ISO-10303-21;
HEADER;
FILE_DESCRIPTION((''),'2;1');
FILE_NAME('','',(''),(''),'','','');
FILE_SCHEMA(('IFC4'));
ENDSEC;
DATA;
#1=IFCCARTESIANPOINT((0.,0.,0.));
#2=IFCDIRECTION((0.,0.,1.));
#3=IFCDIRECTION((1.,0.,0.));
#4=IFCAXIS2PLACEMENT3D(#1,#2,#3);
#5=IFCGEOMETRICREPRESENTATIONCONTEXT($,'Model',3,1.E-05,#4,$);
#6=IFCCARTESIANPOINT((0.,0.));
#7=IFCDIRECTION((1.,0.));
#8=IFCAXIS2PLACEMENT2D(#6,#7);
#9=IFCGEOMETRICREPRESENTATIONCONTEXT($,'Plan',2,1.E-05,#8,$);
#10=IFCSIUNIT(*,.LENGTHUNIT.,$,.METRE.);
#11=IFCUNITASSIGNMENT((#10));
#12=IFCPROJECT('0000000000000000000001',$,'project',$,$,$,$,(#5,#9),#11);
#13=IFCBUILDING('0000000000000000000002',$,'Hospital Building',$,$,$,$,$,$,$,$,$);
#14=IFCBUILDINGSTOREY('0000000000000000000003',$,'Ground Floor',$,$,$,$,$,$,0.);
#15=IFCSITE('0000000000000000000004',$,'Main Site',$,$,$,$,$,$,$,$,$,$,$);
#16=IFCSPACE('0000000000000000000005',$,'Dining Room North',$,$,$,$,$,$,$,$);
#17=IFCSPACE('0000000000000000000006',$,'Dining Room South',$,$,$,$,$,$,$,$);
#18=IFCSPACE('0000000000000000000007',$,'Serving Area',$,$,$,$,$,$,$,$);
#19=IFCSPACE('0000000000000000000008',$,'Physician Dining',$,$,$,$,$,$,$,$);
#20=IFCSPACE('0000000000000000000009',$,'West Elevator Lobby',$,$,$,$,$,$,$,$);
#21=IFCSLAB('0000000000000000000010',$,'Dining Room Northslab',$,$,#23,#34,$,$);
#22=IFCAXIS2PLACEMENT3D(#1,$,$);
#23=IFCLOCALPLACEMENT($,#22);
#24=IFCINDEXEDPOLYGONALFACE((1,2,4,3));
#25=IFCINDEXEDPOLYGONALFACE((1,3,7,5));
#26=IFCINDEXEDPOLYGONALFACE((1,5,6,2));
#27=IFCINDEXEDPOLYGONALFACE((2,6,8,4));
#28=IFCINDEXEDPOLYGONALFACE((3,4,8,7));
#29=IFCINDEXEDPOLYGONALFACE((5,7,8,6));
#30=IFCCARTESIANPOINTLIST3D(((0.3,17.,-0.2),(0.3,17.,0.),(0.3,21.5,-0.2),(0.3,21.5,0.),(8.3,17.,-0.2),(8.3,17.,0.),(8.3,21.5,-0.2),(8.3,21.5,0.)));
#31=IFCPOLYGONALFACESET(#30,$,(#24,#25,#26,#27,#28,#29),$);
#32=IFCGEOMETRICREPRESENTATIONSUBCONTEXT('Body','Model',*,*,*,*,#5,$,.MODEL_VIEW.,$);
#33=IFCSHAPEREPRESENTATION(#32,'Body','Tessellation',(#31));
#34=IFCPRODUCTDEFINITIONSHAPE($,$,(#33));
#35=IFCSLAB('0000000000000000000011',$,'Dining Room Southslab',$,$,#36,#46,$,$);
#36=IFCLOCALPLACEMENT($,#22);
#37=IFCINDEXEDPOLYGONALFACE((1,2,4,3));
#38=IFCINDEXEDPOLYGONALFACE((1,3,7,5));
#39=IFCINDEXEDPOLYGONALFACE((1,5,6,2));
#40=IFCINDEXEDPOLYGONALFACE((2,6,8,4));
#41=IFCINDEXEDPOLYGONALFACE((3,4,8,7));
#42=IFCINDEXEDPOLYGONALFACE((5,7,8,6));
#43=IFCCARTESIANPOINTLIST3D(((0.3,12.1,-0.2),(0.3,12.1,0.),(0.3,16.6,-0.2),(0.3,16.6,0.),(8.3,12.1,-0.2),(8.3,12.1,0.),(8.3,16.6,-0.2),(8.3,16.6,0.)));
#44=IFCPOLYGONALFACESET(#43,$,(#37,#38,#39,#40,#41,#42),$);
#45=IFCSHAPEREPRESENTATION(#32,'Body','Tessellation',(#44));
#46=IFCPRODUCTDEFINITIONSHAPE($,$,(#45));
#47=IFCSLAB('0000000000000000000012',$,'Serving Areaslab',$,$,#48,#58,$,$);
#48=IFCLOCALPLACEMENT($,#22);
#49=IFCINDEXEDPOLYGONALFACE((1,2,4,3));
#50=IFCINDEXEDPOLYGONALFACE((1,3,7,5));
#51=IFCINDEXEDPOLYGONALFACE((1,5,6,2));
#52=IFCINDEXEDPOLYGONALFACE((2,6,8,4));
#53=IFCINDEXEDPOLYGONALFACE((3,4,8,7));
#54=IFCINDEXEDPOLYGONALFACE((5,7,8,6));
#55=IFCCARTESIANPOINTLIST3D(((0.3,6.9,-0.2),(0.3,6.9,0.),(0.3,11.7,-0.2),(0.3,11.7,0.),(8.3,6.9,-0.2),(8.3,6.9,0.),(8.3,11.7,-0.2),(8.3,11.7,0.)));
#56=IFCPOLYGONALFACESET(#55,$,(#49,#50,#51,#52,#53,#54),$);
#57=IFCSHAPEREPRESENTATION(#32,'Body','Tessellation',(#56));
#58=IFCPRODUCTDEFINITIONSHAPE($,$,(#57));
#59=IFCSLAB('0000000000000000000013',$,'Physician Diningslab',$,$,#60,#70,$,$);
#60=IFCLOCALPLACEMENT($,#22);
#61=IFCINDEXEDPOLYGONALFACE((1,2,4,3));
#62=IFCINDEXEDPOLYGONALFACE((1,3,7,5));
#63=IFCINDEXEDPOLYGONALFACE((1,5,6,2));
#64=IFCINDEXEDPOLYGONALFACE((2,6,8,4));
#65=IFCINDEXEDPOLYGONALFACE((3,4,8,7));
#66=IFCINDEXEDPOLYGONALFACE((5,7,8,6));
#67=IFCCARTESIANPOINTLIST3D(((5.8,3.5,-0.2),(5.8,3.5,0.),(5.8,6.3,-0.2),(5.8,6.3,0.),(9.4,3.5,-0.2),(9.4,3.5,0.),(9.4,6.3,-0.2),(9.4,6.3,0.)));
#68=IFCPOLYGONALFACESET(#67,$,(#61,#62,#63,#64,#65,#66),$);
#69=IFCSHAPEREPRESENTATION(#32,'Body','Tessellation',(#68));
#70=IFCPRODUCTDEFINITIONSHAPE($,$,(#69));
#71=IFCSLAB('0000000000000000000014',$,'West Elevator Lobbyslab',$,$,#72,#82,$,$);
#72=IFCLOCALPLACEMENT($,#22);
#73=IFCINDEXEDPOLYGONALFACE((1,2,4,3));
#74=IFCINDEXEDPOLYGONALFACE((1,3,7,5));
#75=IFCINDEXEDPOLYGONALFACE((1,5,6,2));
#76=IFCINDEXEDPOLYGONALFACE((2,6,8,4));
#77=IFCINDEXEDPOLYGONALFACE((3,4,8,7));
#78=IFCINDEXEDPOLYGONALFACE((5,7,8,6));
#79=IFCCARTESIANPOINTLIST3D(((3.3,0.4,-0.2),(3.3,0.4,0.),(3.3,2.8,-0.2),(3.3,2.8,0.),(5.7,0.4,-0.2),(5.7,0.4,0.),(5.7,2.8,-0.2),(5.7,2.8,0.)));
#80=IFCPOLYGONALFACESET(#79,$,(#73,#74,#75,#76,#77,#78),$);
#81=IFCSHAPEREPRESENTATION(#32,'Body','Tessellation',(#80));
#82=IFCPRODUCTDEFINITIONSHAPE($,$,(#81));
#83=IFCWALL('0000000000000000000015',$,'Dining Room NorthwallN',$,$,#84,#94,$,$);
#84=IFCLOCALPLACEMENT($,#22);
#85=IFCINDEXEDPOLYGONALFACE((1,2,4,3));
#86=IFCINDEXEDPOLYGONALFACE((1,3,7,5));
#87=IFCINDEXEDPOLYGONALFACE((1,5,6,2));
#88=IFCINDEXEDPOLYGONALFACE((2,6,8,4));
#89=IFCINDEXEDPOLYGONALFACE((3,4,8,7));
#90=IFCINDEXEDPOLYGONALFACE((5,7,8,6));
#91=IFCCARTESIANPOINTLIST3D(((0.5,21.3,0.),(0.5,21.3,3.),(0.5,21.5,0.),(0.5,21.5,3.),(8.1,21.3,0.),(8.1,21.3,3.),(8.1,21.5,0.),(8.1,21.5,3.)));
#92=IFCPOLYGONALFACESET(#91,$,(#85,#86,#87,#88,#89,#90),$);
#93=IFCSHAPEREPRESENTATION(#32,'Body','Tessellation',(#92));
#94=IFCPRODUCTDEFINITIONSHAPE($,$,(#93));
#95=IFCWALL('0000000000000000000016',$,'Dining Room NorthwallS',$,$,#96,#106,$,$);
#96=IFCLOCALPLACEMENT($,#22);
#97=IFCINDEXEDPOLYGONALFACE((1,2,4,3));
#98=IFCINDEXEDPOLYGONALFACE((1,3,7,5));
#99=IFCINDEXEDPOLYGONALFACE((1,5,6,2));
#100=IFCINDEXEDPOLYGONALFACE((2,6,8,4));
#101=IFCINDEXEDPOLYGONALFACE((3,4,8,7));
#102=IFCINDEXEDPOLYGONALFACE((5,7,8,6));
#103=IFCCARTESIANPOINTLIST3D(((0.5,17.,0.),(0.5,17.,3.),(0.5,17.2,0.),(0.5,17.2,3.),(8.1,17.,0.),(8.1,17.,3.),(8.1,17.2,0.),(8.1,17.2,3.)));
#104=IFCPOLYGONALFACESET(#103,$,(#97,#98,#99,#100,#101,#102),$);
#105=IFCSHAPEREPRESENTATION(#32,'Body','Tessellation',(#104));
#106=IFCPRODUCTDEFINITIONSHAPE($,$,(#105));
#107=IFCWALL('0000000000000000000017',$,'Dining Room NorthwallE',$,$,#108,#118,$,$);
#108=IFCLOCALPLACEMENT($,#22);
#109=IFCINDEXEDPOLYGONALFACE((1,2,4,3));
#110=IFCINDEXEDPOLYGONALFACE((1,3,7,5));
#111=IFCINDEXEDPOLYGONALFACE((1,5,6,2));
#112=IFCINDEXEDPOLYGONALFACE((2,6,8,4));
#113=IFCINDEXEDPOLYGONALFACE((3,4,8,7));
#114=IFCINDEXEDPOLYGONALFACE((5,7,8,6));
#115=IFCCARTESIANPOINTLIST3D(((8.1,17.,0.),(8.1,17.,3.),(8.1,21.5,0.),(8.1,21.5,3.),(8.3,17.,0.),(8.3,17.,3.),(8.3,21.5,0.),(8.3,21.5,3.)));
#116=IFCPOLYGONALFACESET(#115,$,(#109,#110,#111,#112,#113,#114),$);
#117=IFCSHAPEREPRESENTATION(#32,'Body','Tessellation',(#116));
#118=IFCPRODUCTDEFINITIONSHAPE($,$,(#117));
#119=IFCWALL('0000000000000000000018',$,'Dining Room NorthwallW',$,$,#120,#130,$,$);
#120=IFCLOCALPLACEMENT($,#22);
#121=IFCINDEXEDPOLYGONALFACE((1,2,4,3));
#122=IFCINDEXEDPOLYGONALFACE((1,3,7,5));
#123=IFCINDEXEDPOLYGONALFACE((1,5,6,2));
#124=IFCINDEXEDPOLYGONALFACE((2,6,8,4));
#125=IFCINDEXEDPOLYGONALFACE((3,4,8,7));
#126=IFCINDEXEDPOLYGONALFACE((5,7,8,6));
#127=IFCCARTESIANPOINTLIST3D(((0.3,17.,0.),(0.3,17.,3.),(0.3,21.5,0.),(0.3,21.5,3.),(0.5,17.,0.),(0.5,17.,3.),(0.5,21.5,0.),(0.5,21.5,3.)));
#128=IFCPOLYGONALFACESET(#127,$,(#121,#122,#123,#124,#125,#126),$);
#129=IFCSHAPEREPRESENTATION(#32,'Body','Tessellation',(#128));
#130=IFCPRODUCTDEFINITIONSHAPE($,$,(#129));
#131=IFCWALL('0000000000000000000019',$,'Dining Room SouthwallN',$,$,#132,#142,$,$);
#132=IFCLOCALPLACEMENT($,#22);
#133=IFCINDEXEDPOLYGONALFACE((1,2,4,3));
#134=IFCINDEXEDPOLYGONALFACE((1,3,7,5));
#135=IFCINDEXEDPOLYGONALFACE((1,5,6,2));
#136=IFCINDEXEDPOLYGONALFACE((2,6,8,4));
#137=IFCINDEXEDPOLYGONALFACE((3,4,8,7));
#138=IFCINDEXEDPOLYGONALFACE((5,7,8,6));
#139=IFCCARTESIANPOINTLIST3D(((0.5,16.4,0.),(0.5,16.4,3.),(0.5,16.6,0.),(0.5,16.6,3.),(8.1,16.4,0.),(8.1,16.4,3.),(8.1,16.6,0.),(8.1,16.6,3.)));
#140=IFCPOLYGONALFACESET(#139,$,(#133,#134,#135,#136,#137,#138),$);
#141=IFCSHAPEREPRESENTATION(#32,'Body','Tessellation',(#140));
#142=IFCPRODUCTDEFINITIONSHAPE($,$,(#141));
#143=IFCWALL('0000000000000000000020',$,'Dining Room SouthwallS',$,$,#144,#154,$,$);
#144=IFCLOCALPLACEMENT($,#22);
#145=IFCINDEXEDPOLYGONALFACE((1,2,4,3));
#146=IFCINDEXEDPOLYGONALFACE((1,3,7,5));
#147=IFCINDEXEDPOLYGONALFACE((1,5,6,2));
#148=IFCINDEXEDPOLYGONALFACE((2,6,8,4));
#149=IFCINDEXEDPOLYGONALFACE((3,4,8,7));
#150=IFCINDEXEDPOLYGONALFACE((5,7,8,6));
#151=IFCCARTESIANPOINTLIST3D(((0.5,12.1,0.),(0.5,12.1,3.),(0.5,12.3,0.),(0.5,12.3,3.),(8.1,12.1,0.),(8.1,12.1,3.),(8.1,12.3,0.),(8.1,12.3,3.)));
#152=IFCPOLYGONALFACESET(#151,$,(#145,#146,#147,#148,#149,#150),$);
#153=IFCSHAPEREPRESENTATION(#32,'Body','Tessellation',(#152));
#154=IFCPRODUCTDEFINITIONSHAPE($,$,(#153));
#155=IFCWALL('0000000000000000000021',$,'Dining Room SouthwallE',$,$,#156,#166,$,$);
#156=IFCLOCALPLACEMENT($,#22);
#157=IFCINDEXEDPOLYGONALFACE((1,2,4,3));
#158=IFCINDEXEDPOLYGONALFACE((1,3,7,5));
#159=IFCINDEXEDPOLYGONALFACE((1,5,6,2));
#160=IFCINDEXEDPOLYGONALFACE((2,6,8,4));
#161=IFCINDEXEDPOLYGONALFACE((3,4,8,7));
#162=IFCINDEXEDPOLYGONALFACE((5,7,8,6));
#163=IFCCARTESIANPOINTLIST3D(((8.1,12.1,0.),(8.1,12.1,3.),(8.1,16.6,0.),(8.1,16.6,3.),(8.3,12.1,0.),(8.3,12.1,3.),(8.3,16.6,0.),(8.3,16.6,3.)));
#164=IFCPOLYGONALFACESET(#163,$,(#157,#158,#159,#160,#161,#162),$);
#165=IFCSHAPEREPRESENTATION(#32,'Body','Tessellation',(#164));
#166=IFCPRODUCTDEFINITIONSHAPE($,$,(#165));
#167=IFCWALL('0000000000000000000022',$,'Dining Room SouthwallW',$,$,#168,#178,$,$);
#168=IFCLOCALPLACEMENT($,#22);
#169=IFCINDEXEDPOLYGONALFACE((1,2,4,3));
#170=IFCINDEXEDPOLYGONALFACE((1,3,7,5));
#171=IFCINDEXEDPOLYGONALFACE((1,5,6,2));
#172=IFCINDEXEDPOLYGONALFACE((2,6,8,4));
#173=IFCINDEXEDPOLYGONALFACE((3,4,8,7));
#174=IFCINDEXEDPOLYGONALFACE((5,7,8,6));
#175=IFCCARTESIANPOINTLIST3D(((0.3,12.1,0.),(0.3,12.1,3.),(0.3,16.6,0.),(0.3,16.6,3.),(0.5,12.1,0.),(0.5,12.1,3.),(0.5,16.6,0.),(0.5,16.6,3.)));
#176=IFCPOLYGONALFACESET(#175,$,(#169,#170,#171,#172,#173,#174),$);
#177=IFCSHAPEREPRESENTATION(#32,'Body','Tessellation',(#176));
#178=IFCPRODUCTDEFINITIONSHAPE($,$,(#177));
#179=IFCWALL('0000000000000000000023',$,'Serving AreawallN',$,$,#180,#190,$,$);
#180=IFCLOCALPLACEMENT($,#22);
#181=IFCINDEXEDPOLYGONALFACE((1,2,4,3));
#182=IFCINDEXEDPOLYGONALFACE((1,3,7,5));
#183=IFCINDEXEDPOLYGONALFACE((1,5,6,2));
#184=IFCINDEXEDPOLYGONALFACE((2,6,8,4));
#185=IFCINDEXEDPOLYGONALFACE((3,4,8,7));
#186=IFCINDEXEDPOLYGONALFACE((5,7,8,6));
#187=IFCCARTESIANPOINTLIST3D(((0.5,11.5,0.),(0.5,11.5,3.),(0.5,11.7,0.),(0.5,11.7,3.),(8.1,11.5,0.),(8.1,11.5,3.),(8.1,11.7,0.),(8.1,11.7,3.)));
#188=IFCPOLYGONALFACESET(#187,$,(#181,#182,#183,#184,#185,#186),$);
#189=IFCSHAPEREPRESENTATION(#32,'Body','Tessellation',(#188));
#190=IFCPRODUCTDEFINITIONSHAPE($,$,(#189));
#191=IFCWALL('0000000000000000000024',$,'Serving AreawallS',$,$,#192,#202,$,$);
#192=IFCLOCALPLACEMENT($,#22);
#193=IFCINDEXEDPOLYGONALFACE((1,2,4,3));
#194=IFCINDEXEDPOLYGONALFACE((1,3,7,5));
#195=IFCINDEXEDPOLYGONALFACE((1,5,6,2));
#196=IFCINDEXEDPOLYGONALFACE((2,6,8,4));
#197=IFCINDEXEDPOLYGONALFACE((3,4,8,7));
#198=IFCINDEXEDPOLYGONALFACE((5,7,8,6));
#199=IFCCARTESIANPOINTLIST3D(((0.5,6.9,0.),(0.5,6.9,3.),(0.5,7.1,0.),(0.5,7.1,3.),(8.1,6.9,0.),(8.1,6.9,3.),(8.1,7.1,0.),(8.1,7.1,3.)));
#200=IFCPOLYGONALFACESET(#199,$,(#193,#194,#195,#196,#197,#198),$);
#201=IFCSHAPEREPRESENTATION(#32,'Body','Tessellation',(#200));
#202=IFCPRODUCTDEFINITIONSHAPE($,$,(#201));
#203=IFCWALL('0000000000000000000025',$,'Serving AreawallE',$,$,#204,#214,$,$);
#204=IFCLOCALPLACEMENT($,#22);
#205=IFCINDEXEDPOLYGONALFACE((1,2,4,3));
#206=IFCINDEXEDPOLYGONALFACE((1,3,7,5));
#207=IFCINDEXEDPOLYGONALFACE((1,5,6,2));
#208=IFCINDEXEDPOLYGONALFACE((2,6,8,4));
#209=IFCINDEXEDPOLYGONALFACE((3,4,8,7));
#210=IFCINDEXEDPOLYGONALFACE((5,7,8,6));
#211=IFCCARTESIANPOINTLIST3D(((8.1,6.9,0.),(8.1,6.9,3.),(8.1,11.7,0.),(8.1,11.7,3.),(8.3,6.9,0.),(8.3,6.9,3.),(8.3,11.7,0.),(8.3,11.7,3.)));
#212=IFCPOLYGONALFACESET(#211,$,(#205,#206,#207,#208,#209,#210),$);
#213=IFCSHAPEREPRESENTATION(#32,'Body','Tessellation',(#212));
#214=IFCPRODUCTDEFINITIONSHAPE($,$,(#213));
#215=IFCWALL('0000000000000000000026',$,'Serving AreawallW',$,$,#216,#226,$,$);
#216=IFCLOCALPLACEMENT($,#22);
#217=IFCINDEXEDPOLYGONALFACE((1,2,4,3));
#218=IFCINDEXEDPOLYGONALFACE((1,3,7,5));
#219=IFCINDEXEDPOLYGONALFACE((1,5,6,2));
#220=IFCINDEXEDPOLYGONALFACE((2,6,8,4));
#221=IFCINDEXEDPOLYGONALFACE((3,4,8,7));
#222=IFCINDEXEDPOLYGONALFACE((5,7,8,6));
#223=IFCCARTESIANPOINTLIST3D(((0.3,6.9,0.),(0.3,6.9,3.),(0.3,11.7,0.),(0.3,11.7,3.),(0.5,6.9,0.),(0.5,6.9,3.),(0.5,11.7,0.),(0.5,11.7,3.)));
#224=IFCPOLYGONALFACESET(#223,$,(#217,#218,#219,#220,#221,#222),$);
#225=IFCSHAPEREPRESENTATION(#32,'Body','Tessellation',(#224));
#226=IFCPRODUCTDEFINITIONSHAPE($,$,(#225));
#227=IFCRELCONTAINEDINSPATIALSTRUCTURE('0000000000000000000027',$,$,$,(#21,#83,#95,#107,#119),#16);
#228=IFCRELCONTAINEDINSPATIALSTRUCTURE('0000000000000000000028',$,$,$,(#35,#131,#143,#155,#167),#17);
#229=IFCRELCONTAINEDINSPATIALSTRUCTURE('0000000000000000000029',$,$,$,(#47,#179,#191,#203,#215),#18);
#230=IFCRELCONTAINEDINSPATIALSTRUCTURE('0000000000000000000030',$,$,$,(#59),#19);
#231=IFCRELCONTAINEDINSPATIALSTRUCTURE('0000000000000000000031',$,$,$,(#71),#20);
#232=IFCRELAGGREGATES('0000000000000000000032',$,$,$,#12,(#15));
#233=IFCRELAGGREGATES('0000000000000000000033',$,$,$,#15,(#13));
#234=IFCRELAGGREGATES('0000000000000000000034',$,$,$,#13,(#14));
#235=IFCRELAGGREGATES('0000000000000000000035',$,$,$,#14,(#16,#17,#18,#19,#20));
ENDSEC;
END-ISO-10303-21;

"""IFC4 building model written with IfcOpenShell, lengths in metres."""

from ifc_helpers import new_model, si_unit, frame, origin_with_axes, origin_2d_with_axis, place, context, subcontext, project, spatial, indexed_curve, rectangle, outline, extrude, element, save


model = new_model("IFC4")

# Units and contexts
model_context = context("Model", 3, precision=1e-05, world=origin_with_axes())
plan_context = context("Plan", 2, precision=1e-05, world=origin_2d_with_axis())
body_context = subcontext(model_context, "Body", "Model", "MODEL_VIEW")
ifc_project = project(units=[si_unit("LENGTHUNIT", "METRE")], contexts=[model_context, plan_context])

# Site, building, storey, space
site = spatial("IfcSite", under=ifc_project, Name="Main Site")
building = spatial("IfcBuilding", under=site, Name="Hospital Building")
storey = spatial("IfcBuildingStorey", under=building, Name="Ground Floor", Elevation=0.0)
space_1 = spatial("IfcSpace", under=storey, Name="Dining Room North")

# Slab
slab_1_placement = place(None, frame((4.3, 19.25, -0.2), z_axis=(0.0, 0.0, 1.0), x_axis=(1.0, 0.0, 0.0)))
element("IfcSlab", 1, at=slab_1_placement, inside=space_1, Name="Dining Room Northslab", context=body_context, shape_type="SweptSolid", body=[
    extrude(rectangle(XDim=8.0, YDim=4.5), origin_with_axes(), (0.0, 0.0, 1.0), 0.2),
])

# Shared definitions
space_2 = spatial("IfcSpace", under=storey, Name="Dining Room South")

# Slab
slab_2_placement = place(None, frame((4.3, 14.35, -0.2), z_axis=(0.0, 0.0, 1.0), x_axis=(1.0, 0.0, 0.0)))
element("IfcSlab", 2, at=slab_2_placement, inside=space_2, Name="Dining Room Southslab", context=body_context, shape_type="SweptSolid", body=[
    extrude(rectangle(XDim=8.0, YDim=4.5), origin_with_axes(), (0.0, 0.0, 1.0), 0.2),
])

# Shared definitions
space_3 = spatial("IfcSpace", under=storey, Name="Serving Area")

# Slab
slab_3_placement = place(None, frame((4.3, 9.3, -0.2), z_axis=(0.0, 0.0, 1.0), x_axis=(1.0, 0.0, 0.0)))
element("IfcSlab", 3, at=slab_3_placement, inside=space_3, Name="Serving Areaslab", context=body_context, shape_type="SweptSolid", body=[
    extrude(rectangle(XDim=8.0, YDim=4.8), origin_with_axes(), (0.0, 0.0, 1.0), 0.2),
])

# Shared definitions
space_4 = spatial("IfcSpace", under=storey, Name="Physician Dining")

# Slab
slab_4_placement = place(None, frame((7.6, 4.9, -0.2), z_axis=(0.0, 0.0, 1.0), x_axis=(1.0, 0.0, 0.0)))
element("IfcSlab", 4, at=slab_4_placement, inside=space_4, Name="Physician Diningslab", context=body_context, shape_type="SweptSolid", body=[
    extrude(rectangle(XDim=3.6, YDim=2.8), origin_with_axes(), (0.0, 0.0, 1.0), 0.2),
])

# Shared definitions
space_5 = spatial("IfcSpace", under=storey, Name="West Elevator Lobby")

# Slab
slab_5_placement = place(None, frame((4.5, 1.6, -0.2), z_axis=(0.0, 0.0, 1.0), x_axis=(1.0, 0.0, 0.0)))
element("IfcSlab", 5, at=slab_5_placement, inside=space_5, Name="West Elevator Lobbyslab", context=body_context, shape_type="SweptSolid", body=[
    extrude(rectangle(XDim=2.4, YDim=2.4), origin_with_axes(), (0.0, 0.0, 1.0), 0.2),
])

# Walls
for number, where, z_axis, x_axis, name in (
    (6, (0.5, 21.3, 0.0), (0.0, 0.0, 1.0), (1.0, 0.0, 0.0), "Dining Room NorthwallN"),
    (7, (0.5, 17.0, 0.0), (0.0, 0.0, 1.0), (1.0, 0.0, 0.0), "Dining Room NorthwallS"),
):
    element("IfcWall", number, at=place(None, frame(where, z_axis=z_axis, x_axis=x_axis)), inside=space_1, Name=name, context=body_context, shape_type="SweptSolid", body=[
        extrude(outline(indexed_curve([(0.0, 0.0), (0.0, 0.2), (7.6, 0.2), (7.6, 0.0), (0.0, 0.0)], self_intersect=False)), origin_with_axes(), (0.0, 0.0, 1.0), 3.0),
    ])
for number, where, z_axis, x_axis, name in (
    (8, (8.3, 17.0, 0.0), (0.0, 0.0, 1.0), (0.0, 1.0, 0.0), "Dining Room NorthwallE"),
    (9, (0.5, 17.0, 0.0), (0.0, 0.0, 1.0), (0.0, 1.0, 0.0), "Dining Room NorthwallW"),
):
    element("IfcWall", number, at=place(None, frame(where, z_axis=z_axis, x_axis=x_axis)), inside=space_1, Name=name, context=body_context, shape_type="SweptSolid", body=[
        extrude(outline(indexed_curve([(0.0, 0.0), (0.0, 0.2), (4.5, 0.2), (4.5, 0.0), (0.0, 0.0)], self_intersect=False)), origin_with_axes(), (0.0, 0.0, 1.0), 3.0),
    ])
for number, where, z_axis, x_axis, name in (
    (10, (0.5, 16.4, 0.0), (0.0, 0.0, 1.0), (1.0, 0.0, 0.0), "Dining Room SouthwallN"),
    (11, (0.5, 12.1, 0.0), (0.0, 0.0, 1.0), (1.0, 0.0, 0.0), "Dining Room SouthwallS"),
):
    element("IfcWall", number, at=place(None, frame(where, z_axis=z_axis, x_axis=x_axis)), inside=space_2, Name=name, context=body_context, shape_type="SweptSolid", body=[
        extrude(outline(indexed_curve([(0.0, 0.0), (0.0, 0.2), (7.6, 0.2), (7.6, 0.0), (0.0, 0.0)], self_intersect=False)), origin_with_axes(), (0.0, 0.0, 1.0), 3.0),
    ])
for number, where, z_axis, x_axis, name in (
    (12, (8.3, 12.1, 0.0), (0.0, 0.0, 1.0), (0.0, 1.0, 0.0), "Dining Room SouthwallE"),
    (13, (0.5, 12.1, 0.0), (0.0, 0.0, 1.0), (0.0, 1.0, 0.0), "Dining Room SouthwallW"),
):
    element("IfcWall", number, at=place(None, frame(where, z_axis=z_axis, x_axis=x_axis)), inside=space_2, Name=name, context=body_context, shape_type="SweptSolid", body=[
        extrude(outline(indexed_curve([(0.0, 0.0), (0.0, 0.2), (4.5, 0.2), (4.5, 0.0), (0.0, 0.0)], self_intersect=False)), origin_with_axes(), (0.0, 0.0, 1.0), 3.0),
    ])
for number, where, z_axis, x_axis, name in (
    (14, (0.5, 11.5, 0.0), (0.0, 0.0, 1.0), (1.0, 0.0, 0.0), "Serving AreawallN"),
    (15, (0.5, 6.9, 0.0), (0.0, 0.0, 1.0), (1.0, 0.0, 0.0), "Serving AreawallS"),
):
    element("IfcWall", number, at=place(None, frame(where, z_axis=z_axis, x_axis=x_axis)), inside=space_3, Name=name, context=body_context, shape_type="SweptSolid", body=[
        extrude(outline(indexed_curve([(0.0, 0.0), (0.0, 0.2), (7.6, 0.2), (7.6, 0.0), (0.0, 0.0)], self_intersect=False)), origin_with_axes(), (0.0, 0.0, 1.0), 3.0),
    ])
for number, where, z_axis, x_axis, name in (
    (16, (8.3, 6.9, 0.0), (0.0, 0.0, 1.0), (0.0, 1.0, 0.0), "Serving AreawallE"),
    (17, (0.5, 6.9, 0.0), (0.0, 0.0, 1.0), (0.0, 1.0, 0.0), "Serving AreawallW"),
):
    element("IfcWall", number, at=place(None, frame(where, z_axis=z_axis, x_axis=x_axis)), inside=space_3, Name=name, context=body_context, shape_type="SweptSolid", body=[
        extrude(outline(indexed_curve([(0.0, 0.0), (0.0, 0.2), (4.8, 0.2), (4.8, 0.0), (0.0, 0.0)], self_intersect=False)), origin_with_axes(), (0.0, 0.0, 1.0), 3.0),
    ])

save(model, "model.ifc")
